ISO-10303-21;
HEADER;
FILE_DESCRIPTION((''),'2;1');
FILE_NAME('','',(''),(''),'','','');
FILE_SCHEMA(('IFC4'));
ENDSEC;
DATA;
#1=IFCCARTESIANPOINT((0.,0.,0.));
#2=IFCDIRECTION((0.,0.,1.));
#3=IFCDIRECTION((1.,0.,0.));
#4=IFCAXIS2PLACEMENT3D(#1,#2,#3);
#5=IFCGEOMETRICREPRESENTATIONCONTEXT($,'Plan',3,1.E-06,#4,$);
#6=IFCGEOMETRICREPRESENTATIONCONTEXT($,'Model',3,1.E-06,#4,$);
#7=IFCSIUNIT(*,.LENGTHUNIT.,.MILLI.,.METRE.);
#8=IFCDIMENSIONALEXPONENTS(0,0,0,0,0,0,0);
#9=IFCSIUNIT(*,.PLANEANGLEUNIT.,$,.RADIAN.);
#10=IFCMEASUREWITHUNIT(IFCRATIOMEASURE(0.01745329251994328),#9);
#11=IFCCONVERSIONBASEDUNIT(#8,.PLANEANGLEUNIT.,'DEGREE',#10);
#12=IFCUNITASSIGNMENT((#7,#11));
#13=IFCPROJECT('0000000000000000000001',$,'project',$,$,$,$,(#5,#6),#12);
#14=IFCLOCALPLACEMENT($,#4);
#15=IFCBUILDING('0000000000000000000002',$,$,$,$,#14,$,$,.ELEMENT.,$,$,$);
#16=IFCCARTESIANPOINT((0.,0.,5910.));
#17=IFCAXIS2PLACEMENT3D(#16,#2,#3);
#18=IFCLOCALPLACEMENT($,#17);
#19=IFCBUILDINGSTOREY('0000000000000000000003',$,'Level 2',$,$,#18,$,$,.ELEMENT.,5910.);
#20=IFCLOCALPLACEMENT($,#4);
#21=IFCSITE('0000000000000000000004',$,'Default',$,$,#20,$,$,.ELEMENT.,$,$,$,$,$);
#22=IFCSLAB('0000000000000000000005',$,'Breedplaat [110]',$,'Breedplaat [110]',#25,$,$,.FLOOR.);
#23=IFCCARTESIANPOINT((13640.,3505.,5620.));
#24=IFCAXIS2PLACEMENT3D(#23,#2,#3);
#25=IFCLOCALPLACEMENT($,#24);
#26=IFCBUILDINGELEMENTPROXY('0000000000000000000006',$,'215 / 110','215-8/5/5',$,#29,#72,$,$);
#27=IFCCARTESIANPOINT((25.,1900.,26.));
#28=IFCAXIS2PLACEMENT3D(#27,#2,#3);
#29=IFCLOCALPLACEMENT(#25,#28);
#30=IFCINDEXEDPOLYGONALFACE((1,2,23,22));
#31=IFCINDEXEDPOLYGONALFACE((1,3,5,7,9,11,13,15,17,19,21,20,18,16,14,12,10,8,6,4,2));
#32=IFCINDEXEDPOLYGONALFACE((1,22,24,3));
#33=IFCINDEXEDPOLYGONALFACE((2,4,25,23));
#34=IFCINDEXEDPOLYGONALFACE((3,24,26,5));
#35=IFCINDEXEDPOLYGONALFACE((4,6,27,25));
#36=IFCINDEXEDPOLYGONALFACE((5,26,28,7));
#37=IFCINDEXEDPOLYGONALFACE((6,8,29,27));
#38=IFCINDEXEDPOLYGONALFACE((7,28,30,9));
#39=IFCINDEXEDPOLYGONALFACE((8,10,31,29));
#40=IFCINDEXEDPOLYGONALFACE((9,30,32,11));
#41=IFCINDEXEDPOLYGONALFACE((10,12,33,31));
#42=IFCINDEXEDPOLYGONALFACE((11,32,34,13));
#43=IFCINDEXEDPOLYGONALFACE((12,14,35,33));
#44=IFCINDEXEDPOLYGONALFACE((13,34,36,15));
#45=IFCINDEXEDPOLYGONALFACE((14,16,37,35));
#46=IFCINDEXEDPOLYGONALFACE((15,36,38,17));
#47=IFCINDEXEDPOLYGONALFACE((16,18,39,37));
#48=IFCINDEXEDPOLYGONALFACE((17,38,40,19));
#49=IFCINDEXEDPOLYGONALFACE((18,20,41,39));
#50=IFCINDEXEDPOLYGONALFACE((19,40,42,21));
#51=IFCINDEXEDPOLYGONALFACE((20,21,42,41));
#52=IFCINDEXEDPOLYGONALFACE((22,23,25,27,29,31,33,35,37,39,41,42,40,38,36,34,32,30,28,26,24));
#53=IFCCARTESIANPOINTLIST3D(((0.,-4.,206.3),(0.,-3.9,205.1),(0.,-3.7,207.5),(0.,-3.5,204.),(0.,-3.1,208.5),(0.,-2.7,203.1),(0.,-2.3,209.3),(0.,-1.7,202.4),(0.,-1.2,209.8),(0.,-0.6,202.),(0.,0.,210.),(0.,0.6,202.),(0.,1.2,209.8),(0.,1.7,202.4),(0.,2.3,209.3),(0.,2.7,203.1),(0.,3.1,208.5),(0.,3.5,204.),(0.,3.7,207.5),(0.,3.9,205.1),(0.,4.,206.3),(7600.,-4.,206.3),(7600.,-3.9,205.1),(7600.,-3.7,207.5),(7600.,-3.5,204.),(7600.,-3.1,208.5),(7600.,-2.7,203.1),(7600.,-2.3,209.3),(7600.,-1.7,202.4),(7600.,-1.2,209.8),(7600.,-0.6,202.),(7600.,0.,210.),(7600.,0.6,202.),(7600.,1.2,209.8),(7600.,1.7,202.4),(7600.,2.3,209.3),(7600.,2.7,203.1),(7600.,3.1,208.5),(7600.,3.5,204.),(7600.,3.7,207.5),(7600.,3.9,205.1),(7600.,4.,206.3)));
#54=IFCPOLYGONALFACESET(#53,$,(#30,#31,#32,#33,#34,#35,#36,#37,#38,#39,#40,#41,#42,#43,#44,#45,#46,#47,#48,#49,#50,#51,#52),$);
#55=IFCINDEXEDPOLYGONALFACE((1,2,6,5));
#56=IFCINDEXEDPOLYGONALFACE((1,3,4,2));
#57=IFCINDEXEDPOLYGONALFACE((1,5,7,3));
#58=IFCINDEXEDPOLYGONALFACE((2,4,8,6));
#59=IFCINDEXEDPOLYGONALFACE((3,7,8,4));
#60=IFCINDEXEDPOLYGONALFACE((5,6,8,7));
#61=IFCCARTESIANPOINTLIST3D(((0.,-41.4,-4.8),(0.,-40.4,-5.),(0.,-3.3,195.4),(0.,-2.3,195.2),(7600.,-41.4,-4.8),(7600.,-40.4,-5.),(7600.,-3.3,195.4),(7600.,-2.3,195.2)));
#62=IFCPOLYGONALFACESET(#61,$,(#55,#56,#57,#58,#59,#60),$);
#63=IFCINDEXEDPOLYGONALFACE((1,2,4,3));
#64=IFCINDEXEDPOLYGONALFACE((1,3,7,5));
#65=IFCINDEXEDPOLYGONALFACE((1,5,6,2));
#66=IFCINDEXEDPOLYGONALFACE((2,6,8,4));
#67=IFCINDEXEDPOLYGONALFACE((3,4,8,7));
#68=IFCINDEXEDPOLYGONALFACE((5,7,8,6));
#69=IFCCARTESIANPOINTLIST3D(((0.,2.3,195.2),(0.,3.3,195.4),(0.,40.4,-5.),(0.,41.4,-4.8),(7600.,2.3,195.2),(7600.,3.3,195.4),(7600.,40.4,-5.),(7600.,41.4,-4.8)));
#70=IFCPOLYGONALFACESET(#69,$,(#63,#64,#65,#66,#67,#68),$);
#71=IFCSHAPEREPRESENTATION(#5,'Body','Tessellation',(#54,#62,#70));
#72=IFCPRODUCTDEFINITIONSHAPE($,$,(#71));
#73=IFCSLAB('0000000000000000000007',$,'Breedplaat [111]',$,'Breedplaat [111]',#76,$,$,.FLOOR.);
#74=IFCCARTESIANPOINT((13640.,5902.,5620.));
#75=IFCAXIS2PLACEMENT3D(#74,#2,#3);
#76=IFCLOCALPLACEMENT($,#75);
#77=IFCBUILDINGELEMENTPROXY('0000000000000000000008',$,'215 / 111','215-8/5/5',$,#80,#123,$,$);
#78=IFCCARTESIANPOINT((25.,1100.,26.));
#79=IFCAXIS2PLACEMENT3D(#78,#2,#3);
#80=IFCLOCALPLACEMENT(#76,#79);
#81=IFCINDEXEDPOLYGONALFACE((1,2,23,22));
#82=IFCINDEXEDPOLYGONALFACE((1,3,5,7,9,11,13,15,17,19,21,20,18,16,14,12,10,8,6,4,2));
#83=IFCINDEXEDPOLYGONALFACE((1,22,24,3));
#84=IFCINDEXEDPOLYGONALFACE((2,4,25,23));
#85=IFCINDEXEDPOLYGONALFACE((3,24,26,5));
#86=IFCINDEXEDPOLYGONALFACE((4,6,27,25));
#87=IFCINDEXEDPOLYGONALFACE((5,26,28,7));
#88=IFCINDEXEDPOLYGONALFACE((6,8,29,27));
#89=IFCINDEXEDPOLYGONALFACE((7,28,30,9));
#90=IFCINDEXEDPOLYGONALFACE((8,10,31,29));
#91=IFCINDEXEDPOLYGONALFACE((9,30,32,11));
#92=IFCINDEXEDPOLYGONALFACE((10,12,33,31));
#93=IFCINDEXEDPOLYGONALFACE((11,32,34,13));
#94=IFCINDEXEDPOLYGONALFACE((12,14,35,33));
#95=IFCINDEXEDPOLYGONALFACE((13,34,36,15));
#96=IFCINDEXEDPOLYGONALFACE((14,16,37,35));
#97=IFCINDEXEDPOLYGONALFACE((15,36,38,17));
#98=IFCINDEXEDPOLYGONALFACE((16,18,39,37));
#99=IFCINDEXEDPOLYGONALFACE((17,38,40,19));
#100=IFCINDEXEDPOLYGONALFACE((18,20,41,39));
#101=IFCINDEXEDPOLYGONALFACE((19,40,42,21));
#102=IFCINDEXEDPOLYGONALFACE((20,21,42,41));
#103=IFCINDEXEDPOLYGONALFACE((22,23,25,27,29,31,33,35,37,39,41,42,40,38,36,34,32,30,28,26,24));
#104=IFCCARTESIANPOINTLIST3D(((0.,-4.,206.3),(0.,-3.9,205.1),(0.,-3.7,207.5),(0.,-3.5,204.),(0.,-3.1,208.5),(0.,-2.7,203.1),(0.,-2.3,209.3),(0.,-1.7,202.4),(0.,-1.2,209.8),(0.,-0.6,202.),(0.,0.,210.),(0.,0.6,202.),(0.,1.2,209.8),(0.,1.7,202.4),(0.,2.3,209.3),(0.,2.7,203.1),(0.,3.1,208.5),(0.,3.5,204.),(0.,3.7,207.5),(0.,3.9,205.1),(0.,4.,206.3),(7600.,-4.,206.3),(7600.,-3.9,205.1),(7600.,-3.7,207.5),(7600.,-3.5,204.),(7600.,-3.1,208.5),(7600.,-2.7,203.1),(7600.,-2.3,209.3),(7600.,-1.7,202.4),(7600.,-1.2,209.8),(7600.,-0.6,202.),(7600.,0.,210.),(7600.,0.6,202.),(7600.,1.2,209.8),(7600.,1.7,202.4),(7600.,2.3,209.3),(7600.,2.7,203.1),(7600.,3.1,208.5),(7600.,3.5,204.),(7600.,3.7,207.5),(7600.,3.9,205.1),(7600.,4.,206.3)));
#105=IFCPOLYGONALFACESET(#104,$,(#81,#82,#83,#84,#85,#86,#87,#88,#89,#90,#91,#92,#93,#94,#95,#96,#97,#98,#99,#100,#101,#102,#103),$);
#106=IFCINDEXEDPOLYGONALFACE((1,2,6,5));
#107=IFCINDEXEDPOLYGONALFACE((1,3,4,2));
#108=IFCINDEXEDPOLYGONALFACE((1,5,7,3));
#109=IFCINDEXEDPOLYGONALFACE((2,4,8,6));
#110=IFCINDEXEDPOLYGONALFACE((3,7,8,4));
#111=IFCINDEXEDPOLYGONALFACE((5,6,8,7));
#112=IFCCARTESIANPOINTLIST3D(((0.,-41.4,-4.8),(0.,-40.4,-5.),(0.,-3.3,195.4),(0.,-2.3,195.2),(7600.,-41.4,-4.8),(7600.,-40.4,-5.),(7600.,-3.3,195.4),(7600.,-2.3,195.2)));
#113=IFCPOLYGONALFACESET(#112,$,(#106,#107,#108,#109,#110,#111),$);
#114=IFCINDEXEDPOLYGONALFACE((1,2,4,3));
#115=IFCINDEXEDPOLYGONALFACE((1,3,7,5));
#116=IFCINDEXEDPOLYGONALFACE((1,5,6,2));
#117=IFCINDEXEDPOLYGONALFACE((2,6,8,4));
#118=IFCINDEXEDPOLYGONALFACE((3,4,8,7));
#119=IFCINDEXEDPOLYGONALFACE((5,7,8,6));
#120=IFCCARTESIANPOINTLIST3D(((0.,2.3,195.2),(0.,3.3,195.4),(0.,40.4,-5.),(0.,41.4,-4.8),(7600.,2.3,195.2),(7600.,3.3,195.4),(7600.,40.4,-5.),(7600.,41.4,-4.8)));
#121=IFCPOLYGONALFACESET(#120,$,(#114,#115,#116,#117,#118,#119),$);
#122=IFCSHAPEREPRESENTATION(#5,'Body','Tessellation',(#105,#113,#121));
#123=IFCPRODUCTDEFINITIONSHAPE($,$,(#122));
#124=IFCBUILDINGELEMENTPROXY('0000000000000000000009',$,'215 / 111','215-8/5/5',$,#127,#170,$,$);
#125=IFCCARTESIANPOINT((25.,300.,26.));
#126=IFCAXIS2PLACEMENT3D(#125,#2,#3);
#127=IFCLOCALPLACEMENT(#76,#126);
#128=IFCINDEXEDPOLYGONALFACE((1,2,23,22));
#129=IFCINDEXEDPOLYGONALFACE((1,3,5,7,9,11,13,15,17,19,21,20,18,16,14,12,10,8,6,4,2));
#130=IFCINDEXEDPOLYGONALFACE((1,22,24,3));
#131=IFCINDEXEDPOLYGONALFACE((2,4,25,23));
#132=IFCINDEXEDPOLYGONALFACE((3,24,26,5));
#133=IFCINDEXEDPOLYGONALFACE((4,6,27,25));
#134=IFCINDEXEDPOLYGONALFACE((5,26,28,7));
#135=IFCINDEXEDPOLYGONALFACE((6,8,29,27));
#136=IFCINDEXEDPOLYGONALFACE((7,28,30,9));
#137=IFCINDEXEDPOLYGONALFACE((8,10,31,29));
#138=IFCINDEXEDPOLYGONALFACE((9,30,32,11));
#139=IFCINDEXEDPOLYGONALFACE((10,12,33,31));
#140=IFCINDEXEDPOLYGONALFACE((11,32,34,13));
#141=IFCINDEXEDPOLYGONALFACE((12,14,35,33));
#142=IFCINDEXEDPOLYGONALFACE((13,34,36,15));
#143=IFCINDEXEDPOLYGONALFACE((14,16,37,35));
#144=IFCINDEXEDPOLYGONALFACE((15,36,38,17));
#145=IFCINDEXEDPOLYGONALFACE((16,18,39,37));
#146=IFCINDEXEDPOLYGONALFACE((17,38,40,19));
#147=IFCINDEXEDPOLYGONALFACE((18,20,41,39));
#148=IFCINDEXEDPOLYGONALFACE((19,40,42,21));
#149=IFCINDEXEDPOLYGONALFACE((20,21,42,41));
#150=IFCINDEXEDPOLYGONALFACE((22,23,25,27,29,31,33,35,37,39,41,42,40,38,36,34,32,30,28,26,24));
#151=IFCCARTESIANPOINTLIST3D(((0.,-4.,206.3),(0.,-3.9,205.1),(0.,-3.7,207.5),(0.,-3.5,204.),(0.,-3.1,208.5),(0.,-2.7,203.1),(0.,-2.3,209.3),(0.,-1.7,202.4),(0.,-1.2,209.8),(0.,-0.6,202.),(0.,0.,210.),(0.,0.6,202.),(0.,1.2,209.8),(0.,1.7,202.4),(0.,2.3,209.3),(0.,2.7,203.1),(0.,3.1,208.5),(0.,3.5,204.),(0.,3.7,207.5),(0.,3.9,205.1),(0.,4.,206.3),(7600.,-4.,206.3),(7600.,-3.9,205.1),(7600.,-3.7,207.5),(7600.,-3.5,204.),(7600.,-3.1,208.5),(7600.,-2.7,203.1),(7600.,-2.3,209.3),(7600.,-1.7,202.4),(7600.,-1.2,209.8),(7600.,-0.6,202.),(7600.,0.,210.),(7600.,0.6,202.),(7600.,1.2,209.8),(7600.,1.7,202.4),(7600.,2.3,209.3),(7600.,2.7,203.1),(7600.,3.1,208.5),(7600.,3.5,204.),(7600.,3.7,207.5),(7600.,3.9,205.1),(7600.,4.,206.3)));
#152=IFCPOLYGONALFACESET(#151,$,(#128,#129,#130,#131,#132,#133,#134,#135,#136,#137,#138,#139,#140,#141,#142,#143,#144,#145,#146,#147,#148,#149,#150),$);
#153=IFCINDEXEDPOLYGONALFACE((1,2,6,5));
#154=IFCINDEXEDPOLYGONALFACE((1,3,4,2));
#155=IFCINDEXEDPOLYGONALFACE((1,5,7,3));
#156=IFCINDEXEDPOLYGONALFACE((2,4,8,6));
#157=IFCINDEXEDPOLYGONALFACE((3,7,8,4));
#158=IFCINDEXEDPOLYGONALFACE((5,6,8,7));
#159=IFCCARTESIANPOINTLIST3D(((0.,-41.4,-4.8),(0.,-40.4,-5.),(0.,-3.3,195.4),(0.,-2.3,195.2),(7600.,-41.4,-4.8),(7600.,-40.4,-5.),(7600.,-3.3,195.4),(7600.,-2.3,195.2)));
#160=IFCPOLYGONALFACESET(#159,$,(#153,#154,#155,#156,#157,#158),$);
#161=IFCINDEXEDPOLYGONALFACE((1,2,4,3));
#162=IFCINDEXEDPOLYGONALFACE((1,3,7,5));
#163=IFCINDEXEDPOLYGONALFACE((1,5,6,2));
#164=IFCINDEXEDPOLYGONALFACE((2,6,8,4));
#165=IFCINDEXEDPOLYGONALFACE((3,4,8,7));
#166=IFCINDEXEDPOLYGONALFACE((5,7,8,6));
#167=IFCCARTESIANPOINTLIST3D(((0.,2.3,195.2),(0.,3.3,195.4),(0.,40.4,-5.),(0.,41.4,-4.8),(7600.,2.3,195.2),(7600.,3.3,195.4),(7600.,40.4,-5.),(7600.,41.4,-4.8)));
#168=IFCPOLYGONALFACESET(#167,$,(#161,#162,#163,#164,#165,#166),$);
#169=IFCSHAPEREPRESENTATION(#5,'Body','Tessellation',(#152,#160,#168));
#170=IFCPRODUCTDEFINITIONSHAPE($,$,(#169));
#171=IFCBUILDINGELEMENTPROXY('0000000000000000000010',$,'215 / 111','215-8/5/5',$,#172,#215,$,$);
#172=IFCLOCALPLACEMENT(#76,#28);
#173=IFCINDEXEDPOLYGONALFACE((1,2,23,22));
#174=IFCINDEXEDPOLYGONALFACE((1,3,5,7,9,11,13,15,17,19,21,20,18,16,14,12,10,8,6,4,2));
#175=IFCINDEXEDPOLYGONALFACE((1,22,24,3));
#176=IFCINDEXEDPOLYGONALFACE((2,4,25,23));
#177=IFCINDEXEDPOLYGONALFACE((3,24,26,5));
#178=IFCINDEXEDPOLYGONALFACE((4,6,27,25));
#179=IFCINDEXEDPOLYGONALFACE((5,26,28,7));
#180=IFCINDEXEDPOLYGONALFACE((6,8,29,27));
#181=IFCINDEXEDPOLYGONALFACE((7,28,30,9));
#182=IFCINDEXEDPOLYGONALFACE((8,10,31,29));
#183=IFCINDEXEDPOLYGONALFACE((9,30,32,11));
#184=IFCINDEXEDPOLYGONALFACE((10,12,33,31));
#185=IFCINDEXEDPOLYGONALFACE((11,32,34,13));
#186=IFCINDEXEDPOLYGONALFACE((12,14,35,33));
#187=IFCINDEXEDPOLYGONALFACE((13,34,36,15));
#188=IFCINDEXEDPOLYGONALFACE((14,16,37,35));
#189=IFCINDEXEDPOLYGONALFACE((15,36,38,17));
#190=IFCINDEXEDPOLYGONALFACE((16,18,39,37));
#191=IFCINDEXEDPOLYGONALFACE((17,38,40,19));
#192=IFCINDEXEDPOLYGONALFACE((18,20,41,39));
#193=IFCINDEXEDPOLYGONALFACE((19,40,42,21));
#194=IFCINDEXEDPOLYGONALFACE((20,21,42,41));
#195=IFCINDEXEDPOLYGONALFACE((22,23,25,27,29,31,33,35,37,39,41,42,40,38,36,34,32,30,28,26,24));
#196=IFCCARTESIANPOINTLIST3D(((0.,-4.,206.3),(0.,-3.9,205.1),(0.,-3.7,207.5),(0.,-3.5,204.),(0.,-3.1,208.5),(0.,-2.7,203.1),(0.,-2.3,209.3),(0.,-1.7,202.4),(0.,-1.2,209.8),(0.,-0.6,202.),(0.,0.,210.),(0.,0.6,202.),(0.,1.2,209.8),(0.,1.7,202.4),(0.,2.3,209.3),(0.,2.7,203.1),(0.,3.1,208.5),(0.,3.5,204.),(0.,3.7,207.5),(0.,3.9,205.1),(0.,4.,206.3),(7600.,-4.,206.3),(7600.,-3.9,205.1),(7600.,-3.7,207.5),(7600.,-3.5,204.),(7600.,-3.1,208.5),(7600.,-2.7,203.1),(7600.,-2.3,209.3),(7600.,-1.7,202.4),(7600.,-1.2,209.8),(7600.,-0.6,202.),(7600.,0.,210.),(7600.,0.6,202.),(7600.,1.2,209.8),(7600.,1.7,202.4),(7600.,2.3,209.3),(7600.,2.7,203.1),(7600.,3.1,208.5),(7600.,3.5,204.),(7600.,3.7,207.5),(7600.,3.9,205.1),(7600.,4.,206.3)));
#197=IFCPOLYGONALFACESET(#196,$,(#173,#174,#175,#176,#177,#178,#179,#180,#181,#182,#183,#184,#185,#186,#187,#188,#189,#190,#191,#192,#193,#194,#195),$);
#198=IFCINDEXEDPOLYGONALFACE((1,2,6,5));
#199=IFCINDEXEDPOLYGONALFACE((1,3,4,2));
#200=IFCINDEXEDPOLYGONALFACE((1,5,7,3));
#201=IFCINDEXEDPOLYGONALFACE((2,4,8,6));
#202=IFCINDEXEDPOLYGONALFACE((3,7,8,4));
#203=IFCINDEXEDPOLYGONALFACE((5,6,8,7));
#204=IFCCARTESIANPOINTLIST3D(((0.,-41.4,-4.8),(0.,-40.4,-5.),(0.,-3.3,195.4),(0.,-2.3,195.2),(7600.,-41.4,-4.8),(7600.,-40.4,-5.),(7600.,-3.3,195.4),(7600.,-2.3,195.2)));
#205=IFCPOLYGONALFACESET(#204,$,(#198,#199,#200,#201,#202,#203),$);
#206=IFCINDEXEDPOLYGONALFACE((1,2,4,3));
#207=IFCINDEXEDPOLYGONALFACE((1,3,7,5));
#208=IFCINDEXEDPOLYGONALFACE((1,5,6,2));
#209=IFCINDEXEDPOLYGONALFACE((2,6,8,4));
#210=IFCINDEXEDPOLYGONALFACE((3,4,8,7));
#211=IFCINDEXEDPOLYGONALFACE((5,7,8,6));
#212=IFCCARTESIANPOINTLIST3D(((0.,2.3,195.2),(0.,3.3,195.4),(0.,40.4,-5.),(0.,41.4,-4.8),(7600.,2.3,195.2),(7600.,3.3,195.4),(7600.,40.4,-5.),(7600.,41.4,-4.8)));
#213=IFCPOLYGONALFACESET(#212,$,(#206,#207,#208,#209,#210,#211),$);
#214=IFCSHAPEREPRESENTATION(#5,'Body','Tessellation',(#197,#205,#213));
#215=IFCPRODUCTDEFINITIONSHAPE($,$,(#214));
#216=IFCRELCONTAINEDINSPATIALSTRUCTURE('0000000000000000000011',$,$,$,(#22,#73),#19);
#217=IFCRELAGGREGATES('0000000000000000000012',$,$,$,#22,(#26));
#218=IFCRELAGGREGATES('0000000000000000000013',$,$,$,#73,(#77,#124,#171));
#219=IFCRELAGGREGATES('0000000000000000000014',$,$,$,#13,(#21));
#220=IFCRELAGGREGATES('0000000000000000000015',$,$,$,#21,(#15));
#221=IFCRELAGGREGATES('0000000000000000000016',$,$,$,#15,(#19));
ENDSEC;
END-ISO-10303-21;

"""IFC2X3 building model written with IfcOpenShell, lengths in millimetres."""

from ifc_helpers import new_model, entity, si_unit, converted_unit, frame, origin_with_axes, origin_2d_with_axis, place, context, project, spatial, rectangle, circle, extrude, element, aggregate, save


model = new_model("IFC2X3")

# Units and contexts
plan_context = context("Plan", 3, precision=1e-06, world=origin_with_axes())
model_context = context("Model", 3, precision=1e-06, world=origin_with_axes())
ifc_project = project(units=[si_unit("LENGTHUNIT", "METRE", prefix="MILLI"), converted_unit("PLANEANGLEUNIT", "DEGREE", entity("IfcRatioMeasure", 0.01745329251994328), si_unit("PLANEANGLEUNIT", "RADIAN"), dimensions=[0, 0, 0, 0, 0, 0, 0])], contexts=[plan_context, model_context])

# Site, building, storey
site_placement = place(None, origin_with_axes())
site = spatial("IfcSite", under=ifc_project, at=site_placement, Name="Default", CompositionType="ELEMENT")
building_placement = place(None, origin_with_axes())
building = spatial("IfcBuilding", under=site, at=building_placement, CompositionType="ELEMENT")
storey_placement = place(None, frame((0.0, 0.0, 5910.0), z_axis=(0.0, 0.0, 1.0), x_axis=(1.0, 0.0, 0.0)))
storey = spatial("IfcBuildingStorey", under=building, at=storey_placement, Name="Level 2", CompositionType="ELEMENT", Elevation=5910.0)

# Slab, building element proxy
slab_1_placement = place(None, frame((13640.0, 3505.0, 5620.0), z_axis=(0.0, 0.0, 1.0), x_axis=(1.0, 0.0, 0.0)))
slab_1 = element("IfcSlab", 1, at=slab_1_placement, inside=storey, Name="Breedplaat [110]", ObjectType="Breedplaat [110]", PredefinedType="FLOOR")
proxy_1_placement = place(slab_1_placement, frame((25.0, 1900.0, 26.0), z_axis=(0.0, 0.0, 1.0), x_axis=(1.0, 0.0, 0.0)))
proxy_1 = element("IfcBuildingElementProxy", 2, at=proxy_1_placement, Name="215 / 110", Description="215-8/5/5", context=plan_context, shape_type="SweptSolid", body=[
    extrude(circle(Radius=4.0, at=origin_2d_with_axis()), frame((0.0, 0.0, 206.0), z_axis=(1.0, 0.0, 0.0), x_axis=(0.0, 0.0, 1.0)), (0.0, 0.0, 1.0), 7600.0),
    extrude(rectangle(XDim=203.8, YDim=1.0, at=origin_2d_with_axis()), frame((0.0, -21.9, 95.2), z_axis=(1.0, 0.0, 0.0), x_axis=(0.0, 0.187112, 0.982339)), (0.0, 0.0, 1.0), 7600.0),
    extrude(rectangle(XDim=203.8, YDim=1.0, at=origin_2d_with_axis()), frame((0.0, 21.9, 95.2), z_axis=(1.0, 0.0, 0.0), x_axis=(0.0, -0.187112, 0.982339)), (0.0, 0.0, 1.0), 7600.0),
])
aggregate(slab_1, [proxy_1])

# Slab, building element proxies
slab_2_placement = place(None, frame((13640.0, 5902.0, 5620.0), z_axis=(0.0, 0.0, 1.0), x_axis=(1.0, 0.0, 0.0)))
slab_2 = element("IfcSlab", 3, at=slab_2_placement, inside=storey, Name="Breedplaat [111]", ObjectType="Breedplaat [111]", PredefinedType="FLOOR")
proxy_2_placement = place(slab_2_placement, frame((25.0, 1100.0, 26.0), z_axis=(0.0, 0.0, 1.0), x_axis=(1.0, 0.0, 0.0)))
proxy_2 = element("IfcBuildingElementProxy", 4, at=proxy_2_placement, Name="215 / 111", Description="215-8/5/5", context=plan_context, shape_type="SweptSolid", body=[
    extrude(circle(Radius=4.0, at=origin_2d_with_axis()), frame((0.0, 0.0, 206.0), z_axis=(1.0, 0.0, 0.0), x_axis=(0.0, 0.0, 1.0)), (0.0, 0.0, 1.0), 7600.0),
    extrude(rectangle(XDim=203.8, YDim=1.0, at=origin_2d_with_axis()), frame((0.0, -21.9, 95.2), z_axis=(1.0, 0.0, 0.0), x_axis=(0.0, 0.187112, 0.982339)), (0.0, 0.0, 1.0), 7600.0),
    extrude(rectangle(XDim=203.8, YDim=1.0, at=origin_2d_with_axis()), frame((0.0, 21.9, 95.2), z_axis=(1.0, 0.0, 0.0), x_axis=(0.0, -0.187112, 0.982339)), (0.0, 0.0, 1.0), 7600.0),
])
proxy_3_placement = place(slab_2_placement, frame((25.0, 300.0, 26.0), z_axis=(0.0, 0.0, 1.0), x_axis=(1.0, 0.0, 0.0)))
proxy_3 = element("IfcBuildingElementProxy", 5, at=proxy_3_placement, Name="215 / 111", Description="215-8/5/5", context=plan_context, shape_type="SweptSolid", body=[
    extrude(circle(Radius=4.0, at=origin_2d_with_axis()), frame((0.0, 0.0, 206.0), z_axis=(1.0, 0.0, 0.0), x_axis=(0.0, 0.0, 1.0)), (0.0, 0.0, 1.0), 7600.0),
    extrude(rectangle(XDim=203.8, YDim=1.0, at=origin_2d_with_axis()), frame((0.0, -21.9, 95.2), z_axis=(1.0, 0.0, 0.0), x_axis=(0.0, 0.187112, 0.982339)), (0.0, 0.0, 1.0), 7600.0),
    extrude(rectangle(XDim=203.8, YDim=1.0, at=origin_2d_with_axis()), frame((0.0, 21.9, 95.2), z_axis=(1.0, 0.0, 0.0), x_axis=(0.0, -0.187112, 0.982339)), (0.0, 0.0, 1.0), 7600.0),
])
proxy_4_placement = place(slab_2_placement, frame((25.0, 1900.0, 26.0), z_axis=(0.0, 0.0, 1.0), x_axis=(1.0, 0.0, 0.0)))
proxy_4 = element("IfcBuildingElementProxy", 6, at=proxy_4_placement, Name="215 / 111", Description="215-8/5/5", context=plan_context, shape_type="SweptSolid", body=[
    extrude(circle(Radius=4.0, at=origin_2d_with_axis()), frame((0.0, 0.0, 206.0), z_axis=(1.0, 0.0, 0.0), x_axis=(0.0, 0.0, 1.0)), (0.0, 0.0, 1.0), 7600.0),
    extrude(rectangle(XDim=203.8, YDim=1.0, at=origin_2d_with_axis()), frame((0.0, -21.9, 95.2), z_axis=(1.0, 0.0, 0.0), x_axis=(0.0, 0.187112, 0.982339)), (0.0, 0.0, 1.0), 7600.0),
    extrude(rectangle(XDim=203.8, YDim=1.0, at=origin_2d_with_axis()), frame((0.0, 21.9, 95.2), z_axis=(1.0, 0.0, 0.0), x_axis=(0.0, -0.187112, 0.982339)), (0.0, 0.0, 1.0), 7600.0),
])
aggregate(slab_2, [proxy_2, proxy_3, proxy_4])

save(model, "model.ifc")
